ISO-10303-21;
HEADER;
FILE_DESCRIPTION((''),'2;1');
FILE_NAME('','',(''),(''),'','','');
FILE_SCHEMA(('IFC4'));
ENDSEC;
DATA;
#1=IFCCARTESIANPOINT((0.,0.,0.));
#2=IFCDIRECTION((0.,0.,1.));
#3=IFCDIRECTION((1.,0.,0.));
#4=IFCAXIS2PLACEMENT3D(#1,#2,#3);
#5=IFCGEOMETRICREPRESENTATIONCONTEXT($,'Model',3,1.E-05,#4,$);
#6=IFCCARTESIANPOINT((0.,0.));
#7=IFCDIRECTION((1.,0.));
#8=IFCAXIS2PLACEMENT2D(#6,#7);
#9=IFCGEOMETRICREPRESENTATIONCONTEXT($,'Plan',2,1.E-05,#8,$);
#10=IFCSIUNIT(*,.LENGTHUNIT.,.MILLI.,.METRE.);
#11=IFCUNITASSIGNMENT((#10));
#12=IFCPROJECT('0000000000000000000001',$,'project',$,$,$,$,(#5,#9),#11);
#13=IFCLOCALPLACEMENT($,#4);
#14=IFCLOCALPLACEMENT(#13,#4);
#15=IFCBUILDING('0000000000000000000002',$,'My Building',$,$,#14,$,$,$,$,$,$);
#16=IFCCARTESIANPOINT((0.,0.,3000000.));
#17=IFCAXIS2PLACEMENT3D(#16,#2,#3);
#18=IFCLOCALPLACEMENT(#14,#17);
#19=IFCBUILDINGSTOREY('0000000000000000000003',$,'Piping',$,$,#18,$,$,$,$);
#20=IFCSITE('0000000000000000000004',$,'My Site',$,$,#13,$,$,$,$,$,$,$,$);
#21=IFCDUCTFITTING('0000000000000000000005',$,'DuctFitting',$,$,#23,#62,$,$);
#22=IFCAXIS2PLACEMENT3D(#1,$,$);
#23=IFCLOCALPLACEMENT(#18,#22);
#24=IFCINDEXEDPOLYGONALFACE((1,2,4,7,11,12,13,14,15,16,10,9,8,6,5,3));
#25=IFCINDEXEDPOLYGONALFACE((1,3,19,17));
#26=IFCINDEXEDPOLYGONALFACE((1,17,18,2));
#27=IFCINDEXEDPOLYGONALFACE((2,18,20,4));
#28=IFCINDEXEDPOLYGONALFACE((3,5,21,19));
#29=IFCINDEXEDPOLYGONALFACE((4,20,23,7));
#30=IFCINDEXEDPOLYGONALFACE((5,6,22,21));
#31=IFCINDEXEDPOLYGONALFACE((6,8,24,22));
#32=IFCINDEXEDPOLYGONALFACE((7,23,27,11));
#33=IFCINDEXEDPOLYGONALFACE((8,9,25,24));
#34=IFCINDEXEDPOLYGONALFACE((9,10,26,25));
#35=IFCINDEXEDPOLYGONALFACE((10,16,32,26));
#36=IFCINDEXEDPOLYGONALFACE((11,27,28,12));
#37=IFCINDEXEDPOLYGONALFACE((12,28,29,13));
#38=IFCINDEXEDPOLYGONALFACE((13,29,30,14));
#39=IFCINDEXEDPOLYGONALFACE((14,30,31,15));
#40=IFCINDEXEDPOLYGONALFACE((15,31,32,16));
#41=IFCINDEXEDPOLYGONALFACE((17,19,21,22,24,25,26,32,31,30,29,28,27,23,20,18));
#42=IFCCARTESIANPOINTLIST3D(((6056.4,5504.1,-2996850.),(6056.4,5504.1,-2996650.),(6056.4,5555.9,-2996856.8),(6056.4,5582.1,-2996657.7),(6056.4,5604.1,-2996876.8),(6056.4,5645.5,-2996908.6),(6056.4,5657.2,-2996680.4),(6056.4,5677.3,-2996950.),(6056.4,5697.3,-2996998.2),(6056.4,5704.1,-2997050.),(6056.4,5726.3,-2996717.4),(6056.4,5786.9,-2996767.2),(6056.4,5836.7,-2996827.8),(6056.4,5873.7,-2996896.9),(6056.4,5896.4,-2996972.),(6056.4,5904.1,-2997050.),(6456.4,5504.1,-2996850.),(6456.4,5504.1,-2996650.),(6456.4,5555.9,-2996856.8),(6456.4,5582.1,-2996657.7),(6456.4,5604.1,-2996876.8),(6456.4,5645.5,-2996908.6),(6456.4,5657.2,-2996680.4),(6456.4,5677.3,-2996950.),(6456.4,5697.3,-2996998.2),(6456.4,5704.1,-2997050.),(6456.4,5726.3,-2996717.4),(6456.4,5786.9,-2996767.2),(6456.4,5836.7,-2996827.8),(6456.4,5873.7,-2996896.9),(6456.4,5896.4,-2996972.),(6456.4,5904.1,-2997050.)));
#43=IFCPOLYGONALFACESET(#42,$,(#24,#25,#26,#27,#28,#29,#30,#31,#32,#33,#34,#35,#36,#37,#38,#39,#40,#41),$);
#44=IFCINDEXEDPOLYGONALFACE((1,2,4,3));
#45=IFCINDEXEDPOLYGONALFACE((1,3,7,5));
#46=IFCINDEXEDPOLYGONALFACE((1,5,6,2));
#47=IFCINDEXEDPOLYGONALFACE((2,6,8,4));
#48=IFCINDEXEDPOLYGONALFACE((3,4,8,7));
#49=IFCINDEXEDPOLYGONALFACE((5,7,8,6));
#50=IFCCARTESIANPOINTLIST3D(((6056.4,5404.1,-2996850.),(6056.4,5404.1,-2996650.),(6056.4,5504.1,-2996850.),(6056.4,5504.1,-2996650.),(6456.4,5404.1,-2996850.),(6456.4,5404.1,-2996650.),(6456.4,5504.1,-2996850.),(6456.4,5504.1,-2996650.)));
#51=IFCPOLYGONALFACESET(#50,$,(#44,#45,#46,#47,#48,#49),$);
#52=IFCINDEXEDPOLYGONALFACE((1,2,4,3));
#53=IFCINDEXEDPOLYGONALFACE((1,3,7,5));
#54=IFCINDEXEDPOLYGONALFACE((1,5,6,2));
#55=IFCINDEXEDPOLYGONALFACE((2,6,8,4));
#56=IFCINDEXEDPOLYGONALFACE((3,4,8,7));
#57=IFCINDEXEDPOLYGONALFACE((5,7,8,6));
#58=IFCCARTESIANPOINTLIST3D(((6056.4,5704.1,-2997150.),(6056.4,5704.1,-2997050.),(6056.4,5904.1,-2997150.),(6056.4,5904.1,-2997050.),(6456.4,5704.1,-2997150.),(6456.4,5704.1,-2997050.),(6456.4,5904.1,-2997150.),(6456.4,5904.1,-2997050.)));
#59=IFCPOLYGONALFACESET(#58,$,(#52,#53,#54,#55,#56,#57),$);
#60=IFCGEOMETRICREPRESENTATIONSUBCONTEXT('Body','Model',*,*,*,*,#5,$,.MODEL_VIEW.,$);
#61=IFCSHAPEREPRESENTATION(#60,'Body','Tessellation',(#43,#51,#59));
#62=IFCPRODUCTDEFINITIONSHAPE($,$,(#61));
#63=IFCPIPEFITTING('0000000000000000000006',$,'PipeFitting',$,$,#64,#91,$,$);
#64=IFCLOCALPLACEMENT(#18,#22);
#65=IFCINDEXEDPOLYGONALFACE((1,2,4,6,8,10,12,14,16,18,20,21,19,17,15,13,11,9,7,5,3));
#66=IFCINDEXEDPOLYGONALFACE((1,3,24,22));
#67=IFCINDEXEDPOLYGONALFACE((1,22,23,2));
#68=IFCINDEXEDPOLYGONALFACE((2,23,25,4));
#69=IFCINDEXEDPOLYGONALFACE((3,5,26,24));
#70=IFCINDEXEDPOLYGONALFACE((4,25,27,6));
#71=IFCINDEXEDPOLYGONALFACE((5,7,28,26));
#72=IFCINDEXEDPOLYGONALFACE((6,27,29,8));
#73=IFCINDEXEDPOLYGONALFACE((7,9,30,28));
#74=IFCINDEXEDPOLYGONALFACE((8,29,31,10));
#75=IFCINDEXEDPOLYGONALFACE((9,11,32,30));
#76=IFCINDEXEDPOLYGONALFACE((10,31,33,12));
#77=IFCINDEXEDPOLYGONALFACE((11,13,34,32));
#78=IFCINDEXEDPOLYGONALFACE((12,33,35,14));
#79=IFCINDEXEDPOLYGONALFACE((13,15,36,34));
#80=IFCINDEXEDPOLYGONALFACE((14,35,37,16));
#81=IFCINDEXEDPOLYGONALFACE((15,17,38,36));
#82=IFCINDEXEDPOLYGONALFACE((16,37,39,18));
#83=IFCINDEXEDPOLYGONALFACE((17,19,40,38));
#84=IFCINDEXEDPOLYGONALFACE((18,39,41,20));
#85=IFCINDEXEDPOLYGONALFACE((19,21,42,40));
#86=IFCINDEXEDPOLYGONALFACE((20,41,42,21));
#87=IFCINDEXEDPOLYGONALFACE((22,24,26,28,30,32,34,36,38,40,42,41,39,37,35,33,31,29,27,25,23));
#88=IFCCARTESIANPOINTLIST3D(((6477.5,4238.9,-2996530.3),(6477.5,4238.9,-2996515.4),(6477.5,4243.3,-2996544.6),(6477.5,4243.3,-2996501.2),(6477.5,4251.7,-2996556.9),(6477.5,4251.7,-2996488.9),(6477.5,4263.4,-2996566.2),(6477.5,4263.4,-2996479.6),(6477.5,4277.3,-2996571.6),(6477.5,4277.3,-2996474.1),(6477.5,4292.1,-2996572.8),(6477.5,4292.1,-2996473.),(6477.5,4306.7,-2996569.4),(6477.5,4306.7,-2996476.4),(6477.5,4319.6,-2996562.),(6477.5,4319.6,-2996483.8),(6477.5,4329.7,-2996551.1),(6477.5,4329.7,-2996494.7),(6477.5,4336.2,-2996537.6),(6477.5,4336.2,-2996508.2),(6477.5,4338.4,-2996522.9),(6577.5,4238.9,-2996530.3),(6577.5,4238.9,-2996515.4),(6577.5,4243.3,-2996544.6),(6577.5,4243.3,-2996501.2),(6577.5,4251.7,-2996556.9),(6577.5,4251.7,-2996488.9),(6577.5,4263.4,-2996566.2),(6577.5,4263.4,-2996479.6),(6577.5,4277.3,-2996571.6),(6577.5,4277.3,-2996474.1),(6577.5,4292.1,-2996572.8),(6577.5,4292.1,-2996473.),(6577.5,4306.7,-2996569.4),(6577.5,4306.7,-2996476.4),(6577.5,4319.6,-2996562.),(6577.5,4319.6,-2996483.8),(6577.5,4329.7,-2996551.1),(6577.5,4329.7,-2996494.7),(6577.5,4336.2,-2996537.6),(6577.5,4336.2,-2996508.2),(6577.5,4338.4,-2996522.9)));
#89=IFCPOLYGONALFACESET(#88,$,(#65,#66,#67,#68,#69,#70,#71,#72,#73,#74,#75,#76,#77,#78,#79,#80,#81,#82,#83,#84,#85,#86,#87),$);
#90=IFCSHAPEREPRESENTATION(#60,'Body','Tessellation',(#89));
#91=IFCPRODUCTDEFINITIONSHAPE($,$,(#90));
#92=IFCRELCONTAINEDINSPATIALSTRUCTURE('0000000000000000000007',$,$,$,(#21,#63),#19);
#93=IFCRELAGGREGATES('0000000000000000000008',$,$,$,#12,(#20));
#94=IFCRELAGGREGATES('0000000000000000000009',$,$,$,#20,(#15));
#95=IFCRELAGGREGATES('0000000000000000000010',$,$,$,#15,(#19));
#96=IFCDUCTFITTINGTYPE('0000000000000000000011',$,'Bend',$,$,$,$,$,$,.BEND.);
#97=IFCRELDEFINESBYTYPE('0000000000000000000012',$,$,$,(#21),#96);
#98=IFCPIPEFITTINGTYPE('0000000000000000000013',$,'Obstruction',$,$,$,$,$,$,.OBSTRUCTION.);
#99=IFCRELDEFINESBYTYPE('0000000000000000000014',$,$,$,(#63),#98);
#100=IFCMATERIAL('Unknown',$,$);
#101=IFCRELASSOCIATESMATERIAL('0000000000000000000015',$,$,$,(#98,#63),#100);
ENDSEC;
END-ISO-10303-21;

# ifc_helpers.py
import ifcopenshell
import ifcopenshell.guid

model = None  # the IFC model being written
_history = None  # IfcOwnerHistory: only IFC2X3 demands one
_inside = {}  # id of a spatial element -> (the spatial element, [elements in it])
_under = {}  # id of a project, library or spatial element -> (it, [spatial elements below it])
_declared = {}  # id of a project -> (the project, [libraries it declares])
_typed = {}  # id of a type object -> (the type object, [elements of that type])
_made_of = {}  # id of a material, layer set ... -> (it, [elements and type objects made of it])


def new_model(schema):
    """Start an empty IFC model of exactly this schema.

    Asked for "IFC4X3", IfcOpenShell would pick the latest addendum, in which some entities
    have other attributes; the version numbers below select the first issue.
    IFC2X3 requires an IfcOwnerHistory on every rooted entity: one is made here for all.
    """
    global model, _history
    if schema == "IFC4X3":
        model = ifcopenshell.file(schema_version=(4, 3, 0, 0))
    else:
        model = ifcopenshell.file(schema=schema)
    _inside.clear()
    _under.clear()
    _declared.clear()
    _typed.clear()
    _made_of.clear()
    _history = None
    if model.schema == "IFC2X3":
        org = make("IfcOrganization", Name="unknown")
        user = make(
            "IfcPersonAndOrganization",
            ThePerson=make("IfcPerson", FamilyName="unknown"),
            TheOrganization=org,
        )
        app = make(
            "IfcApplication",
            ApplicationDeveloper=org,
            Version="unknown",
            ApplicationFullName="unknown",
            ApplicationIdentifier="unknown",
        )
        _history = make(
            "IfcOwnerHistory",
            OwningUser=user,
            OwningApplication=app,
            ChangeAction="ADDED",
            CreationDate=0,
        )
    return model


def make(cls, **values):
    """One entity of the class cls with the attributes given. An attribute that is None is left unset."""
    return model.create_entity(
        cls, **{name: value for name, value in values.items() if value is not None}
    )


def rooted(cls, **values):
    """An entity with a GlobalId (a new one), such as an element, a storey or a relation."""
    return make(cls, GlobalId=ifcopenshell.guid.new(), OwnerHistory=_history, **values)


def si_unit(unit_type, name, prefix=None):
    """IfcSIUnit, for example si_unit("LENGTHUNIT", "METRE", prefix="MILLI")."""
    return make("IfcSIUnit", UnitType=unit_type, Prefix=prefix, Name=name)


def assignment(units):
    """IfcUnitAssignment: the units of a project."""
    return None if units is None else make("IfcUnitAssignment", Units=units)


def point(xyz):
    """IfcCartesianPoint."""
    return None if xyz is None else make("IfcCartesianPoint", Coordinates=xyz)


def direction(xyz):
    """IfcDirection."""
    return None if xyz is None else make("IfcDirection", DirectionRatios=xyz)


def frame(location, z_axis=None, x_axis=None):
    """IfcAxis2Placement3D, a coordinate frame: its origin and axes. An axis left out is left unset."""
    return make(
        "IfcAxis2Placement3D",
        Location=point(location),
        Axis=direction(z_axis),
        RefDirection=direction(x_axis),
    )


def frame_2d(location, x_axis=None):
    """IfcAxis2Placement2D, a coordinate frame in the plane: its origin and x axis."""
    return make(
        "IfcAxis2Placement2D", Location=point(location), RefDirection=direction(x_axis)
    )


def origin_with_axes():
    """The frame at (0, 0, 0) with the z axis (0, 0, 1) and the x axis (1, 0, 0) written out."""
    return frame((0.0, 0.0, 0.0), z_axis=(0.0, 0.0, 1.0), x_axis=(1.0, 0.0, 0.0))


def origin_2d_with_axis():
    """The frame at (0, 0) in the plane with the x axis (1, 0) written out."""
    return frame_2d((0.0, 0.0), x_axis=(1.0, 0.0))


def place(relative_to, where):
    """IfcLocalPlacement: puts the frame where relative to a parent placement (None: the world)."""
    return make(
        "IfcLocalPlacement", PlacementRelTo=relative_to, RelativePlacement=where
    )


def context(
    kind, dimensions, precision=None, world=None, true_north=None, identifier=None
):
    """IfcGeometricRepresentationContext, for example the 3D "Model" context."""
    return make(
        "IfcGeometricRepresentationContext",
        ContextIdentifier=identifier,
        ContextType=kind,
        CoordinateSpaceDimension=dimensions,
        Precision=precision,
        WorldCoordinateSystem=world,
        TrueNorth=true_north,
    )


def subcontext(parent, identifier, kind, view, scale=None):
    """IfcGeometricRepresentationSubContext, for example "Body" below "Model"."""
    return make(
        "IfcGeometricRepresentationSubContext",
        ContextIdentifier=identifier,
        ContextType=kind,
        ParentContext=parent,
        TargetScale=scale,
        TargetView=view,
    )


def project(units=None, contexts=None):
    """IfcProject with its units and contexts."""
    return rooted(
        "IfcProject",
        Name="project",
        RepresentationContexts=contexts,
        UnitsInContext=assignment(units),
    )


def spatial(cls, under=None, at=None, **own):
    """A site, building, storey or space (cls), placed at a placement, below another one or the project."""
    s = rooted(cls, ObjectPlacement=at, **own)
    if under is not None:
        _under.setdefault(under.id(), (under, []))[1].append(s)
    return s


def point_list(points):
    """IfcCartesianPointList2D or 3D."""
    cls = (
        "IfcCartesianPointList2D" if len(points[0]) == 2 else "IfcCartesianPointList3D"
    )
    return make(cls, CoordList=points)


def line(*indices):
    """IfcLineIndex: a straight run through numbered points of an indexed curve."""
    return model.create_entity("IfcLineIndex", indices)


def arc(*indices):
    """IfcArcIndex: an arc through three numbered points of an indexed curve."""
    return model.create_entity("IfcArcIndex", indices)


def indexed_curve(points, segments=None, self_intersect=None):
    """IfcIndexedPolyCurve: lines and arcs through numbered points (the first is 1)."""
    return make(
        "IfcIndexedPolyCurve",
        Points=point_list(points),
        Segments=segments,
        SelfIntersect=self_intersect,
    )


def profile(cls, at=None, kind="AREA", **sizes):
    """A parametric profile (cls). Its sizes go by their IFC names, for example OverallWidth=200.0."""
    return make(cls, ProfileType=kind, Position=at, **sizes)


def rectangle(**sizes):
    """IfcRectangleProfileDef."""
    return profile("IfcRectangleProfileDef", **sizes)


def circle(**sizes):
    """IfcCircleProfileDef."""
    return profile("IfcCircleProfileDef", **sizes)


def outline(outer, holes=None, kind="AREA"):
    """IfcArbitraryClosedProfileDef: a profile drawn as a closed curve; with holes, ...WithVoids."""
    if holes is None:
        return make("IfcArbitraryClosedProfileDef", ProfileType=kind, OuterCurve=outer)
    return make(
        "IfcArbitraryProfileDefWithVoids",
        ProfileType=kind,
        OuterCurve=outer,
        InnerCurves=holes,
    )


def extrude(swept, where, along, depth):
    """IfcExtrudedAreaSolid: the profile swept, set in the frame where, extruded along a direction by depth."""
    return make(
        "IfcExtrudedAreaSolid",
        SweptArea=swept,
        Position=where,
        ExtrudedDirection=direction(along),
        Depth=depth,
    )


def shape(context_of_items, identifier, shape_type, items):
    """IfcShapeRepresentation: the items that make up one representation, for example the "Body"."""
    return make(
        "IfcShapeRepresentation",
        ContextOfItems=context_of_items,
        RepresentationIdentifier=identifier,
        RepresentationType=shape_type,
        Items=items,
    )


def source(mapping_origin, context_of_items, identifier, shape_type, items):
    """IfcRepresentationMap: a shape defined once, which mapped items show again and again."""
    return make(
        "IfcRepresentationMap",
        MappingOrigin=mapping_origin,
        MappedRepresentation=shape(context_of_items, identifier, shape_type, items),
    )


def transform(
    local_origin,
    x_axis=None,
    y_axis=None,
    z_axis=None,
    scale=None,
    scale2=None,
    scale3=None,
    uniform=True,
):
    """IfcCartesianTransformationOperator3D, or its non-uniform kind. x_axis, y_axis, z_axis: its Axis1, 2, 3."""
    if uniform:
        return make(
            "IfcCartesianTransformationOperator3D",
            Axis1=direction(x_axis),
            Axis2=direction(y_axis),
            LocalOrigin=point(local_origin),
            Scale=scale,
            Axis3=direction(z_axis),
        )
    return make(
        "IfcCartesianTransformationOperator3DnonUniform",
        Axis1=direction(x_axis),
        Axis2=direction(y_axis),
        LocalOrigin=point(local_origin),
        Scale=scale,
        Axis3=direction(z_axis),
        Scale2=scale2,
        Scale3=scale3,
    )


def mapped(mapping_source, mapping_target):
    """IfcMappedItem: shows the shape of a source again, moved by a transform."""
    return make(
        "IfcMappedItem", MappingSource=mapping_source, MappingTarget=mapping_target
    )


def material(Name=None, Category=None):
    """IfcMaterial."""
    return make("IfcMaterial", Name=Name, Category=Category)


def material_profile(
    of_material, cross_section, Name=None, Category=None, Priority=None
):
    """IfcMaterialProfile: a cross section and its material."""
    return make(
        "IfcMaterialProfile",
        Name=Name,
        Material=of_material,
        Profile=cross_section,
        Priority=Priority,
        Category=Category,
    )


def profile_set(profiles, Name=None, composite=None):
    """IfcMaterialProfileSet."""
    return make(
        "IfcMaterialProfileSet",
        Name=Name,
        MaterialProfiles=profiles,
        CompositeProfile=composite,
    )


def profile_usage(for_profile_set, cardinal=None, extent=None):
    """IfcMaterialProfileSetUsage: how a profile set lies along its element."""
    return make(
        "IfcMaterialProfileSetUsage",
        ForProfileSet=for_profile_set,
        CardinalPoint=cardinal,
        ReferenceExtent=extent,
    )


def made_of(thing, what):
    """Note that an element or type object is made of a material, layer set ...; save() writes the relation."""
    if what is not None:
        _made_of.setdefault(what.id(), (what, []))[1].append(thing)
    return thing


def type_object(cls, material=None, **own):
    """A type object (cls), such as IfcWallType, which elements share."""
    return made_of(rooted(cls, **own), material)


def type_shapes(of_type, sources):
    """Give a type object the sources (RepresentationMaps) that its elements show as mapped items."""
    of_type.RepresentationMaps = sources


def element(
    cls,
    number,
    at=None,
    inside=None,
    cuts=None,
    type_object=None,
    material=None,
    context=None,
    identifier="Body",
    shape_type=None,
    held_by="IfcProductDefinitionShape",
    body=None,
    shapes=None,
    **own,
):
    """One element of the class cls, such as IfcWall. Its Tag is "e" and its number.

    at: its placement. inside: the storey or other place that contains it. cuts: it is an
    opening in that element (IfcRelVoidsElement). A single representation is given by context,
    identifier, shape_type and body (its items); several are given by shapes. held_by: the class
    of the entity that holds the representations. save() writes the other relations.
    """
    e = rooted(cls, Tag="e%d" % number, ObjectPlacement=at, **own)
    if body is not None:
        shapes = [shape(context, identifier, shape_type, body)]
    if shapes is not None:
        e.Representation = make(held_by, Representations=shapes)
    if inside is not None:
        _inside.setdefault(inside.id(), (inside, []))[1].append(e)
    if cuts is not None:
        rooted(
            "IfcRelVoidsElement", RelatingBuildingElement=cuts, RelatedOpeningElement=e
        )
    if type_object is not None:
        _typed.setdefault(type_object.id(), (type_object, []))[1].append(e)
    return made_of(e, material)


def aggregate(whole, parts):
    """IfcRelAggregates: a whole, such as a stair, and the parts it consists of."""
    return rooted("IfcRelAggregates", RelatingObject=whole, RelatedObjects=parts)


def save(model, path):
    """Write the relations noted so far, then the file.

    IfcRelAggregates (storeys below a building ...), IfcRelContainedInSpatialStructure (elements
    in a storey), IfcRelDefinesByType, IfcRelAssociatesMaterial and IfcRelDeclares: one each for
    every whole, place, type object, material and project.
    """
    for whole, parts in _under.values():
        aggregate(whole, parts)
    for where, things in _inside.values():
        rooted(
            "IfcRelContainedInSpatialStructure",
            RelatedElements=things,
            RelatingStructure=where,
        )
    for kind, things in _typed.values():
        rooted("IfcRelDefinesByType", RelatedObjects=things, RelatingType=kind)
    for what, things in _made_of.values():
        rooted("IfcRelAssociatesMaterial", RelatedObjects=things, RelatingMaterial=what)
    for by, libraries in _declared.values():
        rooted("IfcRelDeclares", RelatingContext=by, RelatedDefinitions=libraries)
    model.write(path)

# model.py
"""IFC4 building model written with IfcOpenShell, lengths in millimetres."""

from ifc_helpers import new_model, si_unit, frame, origin_with_axes, origin_2d_with_axis, place, context, subcontext, project, spatial, line, arc, indexed_curve, rectangle, circle, outline, extrude, source, transform, mapped, material, material_profile, profile_set, profile_usage, type_object, type_shapes, element, save


model = new_model("IFC4")

# Units and contexts
model_context = context("Model", 3, precision=1e-05, world=origin_with_axes())
plan_context = context("Plan", 2, precision=1e-05, world=origin_2d_with_axis())
body_context = subcontext(model_context, "Body", "Model", "MODEL_VIEW")
ifc_project = project(units=[si_unit("LENGTHUNIT", "METRE", prefix="MILLI")], contexts=[model_context, plan_context])

# Site, building, storey
site_placement = place(None, origin_with_axes())
site = spatial("IfcSite", under=ifc_project, at=site_placement, Name="My Site")
building_placement = place(site_placement, origin_with_axes())
building = spatial("IfcBuilding", under=site, at=building_placement, Name="My Building")
storey_placement = place(building_placement, frame((0.0, 0.0, 3000000.0), z_axis=(0.0, 0.0, 1.0), x_axis=(1.0, 0.0, 0.0)))
storey = spatial("IfcBuildingStorey", under=building, at=storey_placement, Name="Piping")

# Shared definitions
ifc_material = material(Name="Unknown")

# Duct fitting
duct_fitting_type = type_object("IfcDuctFittingType", Name="Bend", PredefinedType="BEND")
shared_shape_1 = source(origin_with_axes(), body_context, "Body", "SweptSolid", [
    extrude(outline(indexed_curve([(-100.0, 0.0), (-158.6, 141.4), (-300.0, 200.0), (-300.0, 400.0), (-17.2, 282.8), (100.0, 0.0)], segments=[arc(1, 2, 3), line(3, 4), arc(4, 5, 6), line(6, 1)])), frame((-200.0, 0.0, 100.0), z_axis=(1.0, 0.0, 0.0), x_axis=(0.0, 1.0, 0.0)), (0.0, 0.0, 1.0), 400.0),
    extrude(rectangle(XDim=400.0, YDim=200.0), origin_with_axes(), (0.0, 0.0, 1.0), 100.0),
    extrude(rectangle(XDim=400.0, YDim=200.0), frame((0.0, -300.0, 400.0), z_axis=(0.0, -1.0, 0.0), x_axis=(1.0, 0.0, 0.0)), (0.0, 0.0, 1.0), 100.0),
])
type_shapes(duct_fitting_type, [shared_shape_1])
duct_fitting_placement = place(storey_placement, frame((6256.4, 5404.1, -2996750.0), z_axis=(0.0, 1.0, 0.0), x_axis=(-1.0, 0.0, 0.0)))
element("IfcDuctFitting", 1, at=duct_fitting_placement, inside=storey, type_object=duct_fitting_type, Name="DuctFitting", context=body_context, shape_type="MappedRepresentation", body=[
    mapped(shared_shape_1, transform((0.0, 0.0, 0.0), x_axis=(1.0, 0.0, 0.0), y_axis=(0.0, 1.0, 0.0), z_axis=(0.0, 0.0, 1.0), scale=1.0)),
])

# Pipe fitting
ifc_material_profile_1 = material_profile(ifc_material, circle(Radius=50.0))
ifc_profile_set_1 = profile_set([ifc_material_profile_1])
ifc_profile_usage_1 = profile_usage(ifc_profile_set_1, cardinal=5)
pipe_fitting_type_1 = type_object("IfcPipeFittingType", Name="Obstruction", PredefinedType="OBSTRUCTION", material=ifc_profile_set_1)
pipe_fitting_1_placement = place(storey_placement, frame((6477.5, 4288.4, -2996522.9), z_axis=(1.0, 0.0, 0.0), x_axis=(0.0, 1.0, 0.0)))
element("IfcPipeFitting", 2, at=pipe_fitting_1_placement, inside=storey, type_object=pipe_fitting_type_1, material=ifc_profile_usage_1, Name="PipeFitting", context=body_context, shape_type="SweptSolid", body=[
    extrude(circle(Radius=50.0), origin_with_axes(), (0.0, 0.0, 1.0), 100.0),
])

save(model, "model.ifc")
